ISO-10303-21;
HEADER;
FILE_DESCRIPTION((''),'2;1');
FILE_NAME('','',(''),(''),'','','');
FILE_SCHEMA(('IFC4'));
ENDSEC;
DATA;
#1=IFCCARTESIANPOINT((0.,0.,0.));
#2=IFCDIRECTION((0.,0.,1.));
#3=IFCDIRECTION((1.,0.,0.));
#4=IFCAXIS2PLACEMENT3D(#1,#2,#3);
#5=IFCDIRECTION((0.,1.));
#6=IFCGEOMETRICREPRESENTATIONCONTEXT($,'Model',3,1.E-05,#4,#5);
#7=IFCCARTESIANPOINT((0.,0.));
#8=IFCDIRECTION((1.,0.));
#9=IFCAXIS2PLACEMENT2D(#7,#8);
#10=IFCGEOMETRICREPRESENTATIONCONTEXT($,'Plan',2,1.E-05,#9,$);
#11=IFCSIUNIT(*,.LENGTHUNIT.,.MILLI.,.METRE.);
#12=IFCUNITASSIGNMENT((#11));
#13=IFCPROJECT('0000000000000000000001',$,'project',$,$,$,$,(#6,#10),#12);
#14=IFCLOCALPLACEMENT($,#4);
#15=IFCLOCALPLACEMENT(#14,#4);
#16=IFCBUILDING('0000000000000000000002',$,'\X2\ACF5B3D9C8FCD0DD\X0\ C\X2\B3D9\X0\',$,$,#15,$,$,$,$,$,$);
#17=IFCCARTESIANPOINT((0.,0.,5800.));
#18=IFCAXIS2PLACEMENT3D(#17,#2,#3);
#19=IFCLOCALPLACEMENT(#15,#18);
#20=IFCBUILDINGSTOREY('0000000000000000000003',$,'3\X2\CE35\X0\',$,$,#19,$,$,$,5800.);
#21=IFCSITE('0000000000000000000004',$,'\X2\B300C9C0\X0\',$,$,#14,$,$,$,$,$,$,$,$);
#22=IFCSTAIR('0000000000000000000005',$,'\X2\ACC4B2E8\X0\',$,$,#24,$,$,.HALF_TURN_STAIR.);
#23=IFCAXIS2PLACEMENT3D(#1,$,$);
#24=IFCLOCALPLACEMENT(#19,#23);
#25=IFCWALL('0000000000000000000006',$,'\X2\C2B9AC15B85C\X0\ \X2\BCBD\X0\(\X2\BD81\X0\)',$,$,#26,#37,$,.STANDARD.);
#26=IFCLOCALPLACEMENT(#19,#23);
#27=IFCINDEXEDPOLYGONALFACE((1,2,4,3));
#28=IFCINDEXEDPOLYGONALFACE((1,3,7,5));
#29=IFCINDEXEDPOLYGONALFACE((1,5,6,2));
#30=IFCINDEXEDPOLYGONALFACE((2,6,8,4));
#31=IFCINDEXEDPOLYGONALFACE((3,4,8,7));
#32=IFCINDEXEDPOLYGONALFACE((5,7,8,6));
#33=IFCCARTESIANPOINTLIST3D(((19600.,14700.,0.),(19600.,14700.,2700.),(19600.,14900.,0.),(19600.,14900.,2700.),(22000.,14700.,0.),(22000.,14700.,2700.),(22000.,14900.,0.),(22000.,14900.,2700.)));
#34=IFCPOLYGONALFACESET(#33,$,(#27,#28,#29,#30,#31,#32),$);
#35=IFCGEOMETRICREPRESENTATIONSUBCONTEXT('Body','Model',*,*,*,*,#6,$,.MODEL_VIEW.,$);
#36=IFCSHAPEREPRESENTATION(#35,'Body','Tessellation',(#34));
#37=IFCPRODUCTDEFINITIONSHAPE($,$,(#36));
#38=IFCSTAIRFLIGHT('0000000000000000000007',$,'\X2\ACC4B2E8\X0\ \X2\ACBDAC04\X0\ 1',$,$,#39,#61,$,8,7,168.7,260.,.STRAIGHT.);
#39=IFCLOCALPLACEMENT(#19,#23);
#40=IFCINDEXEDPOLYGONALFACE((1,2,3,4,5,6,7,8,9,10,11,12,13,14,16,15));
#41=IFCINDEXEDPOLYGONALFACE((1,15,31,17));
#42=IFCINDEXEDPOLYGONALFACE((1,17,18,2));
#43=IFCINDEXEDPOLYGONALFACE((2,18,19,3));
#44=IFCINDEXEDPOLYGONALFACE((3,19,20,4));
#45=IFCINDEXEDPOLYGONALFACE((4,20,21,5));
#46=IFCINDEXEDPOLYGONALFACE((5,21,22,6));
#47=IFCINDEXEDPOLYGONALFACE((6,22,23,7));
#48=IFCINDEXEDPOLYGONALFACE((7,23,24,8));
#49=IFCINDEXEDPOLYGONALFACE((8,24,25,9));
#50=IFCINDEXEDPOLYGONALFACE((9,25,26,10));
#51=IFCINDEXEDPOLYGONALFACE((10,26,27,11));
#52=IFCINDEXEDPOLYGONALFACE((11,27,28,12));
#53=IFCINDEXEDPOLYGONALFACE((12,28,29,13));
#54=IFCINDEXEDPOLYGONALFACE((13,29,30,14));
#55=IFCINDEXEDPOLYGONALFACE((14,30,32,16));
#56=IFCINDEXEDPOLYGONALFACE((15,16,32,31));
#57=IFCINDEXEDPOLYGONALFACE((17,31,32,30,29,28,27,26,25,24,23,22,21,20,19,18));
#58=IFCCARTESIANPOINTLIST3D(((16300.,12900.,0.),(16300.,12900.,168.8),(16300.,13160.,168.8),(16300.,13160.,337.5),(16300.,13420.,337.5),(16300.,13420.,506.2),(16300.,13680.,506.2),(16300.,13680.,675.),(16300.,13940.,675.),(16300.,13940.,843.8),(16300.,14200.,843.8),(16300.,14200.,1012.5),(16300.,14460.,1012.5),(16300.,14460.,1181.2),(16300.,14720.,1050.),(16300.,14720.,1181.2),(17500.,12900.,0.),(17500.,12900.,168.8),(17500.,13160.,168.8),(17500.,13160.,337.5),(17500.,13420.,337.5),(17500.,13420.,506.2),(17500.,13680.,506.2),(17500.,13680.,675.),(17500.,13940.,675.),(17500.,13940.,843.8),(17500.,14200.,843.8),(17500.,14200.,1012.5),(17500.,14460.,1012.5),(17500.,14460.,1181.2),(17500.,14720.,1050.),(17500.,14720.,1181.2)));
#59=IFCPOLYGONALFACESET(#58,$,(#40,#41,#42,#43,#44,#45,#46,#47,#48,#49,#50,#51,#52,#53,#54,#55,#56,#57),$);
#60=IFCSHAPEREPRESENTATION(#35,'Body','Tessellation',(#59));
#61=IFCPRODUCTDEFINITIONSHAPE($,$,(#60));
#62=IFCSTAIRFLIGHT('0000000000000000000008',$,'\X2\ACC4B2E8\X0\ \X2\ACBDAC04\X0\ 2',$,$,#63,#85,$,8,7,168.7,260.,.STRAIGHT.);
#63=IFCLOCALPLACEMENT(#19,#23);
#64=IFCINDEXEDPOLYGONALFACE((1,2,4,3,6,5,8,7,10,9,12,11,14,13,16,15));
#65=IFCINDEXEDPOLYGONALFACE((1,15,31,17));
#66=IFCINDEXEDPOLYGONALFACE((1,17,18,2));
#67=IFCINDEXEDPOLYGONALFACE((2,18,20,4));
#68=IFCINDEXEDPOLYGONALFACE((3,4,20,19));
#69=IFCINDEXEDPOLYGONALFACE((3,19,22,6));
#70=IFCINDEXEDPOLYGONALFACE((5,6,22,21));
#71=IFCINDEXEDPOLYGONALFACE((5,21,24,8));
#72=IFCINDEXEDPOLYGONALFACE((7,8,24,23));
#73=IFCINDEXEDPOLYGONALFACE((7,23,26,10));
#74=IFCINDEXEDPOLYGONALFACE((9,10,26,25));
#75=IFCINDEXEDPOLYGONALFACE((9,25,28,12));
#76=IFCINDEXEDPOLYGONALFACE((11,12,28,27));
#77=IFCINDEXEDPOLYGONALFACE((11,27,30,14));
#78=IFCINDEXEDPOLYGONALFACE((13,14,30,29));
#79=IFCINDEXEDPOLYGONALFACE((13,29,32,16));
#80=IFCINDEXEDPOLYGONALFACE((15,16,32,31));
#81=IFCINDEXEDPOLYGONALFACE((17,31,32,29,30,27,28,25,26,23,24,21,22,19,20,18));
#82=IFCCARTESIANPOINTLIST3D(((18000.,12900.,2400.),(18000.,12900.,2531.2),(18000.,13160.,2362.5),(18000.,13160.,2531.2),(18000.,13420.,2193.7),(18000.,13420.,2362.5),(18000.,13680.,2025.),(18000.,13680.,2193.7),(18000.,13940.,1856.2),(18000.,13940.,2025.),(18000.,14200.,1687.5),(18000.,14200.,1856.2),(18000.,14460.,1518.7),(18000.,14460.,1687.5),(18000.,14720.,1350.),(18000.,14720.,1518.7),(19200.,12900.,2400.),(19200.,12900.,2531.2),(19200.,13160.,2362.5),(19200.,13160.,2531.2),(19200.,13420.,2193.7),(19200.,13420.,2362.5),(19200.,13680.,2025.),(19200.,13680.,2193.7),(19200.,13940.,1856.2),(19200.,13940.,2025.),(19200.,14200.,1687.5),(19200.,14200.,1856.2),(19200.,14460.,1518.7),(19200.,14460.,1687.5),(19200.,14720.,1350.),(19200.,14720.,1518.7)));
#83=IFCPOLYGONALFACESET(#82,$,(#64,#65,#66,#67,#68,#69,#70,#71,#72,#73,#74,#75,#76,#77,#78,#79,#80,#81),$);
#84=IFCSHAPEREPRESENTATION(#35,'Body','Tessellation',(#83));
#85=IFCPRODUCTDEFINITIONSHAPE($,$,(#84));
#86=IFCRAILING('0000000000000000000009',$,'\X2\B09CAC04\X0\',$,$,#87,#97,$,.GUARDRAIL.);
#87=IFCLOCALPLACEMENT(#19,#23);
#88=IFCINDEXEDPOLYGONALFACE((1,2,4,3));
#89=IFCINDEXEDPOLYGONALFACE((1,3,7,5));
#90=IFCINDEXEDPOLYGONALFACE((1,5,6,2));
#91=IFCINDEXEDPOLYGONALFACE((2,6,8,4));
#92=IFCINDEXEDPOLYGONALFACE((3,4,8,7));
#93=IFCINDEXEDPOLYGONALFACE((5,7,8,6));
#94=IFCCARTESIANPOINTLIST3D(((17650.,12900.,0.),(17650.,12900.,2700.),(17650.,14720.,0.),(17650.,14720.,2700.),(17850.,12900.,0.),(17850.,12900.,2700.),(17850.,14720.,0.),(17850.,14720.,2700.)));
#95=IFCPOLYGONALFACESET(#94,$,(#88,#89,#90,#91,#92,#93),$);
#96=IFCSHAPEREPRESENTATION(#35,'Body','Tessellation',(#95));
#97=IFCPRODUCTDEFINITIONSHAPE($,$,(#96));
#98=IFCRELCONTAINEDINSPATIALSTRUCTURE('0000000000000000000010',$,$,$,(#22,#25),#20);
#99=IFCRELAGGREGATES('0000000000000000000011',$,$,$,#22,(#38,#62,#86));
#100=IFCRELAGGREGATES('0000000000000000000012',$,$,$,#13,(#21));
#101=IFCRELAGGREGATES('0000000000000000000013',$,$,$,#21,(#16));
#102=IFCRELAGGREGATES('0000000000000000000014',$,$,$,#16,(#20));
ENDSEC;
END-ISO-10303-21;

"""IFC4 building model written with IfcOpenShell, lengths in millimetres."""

from ifc_helpers import new_model, si_unit, direction, frame, origin_with_axes, origin_2d_with_axis, place, context, subcontext, project, spatial, polyline, outline, extrude, element, aggregate, save


model = new_model("IFC4")

# Units and contexts
model_context = context("Model", 3, precision=1e-05, world=origin_with_axes(), true_north=direction((0.0, 1.0)))
plan_context = context("Plan", 2, precision=1e-05, world=origin_2d_with_axis())
body_context = subcontext(model_context, "Body", "Model", "MODEL_VIEW")
ifc_project = project(units=[si_unit("LENGTHUNIT", "METRE", prefix="MILLI")], contexts=[model_context, plan_context])

# Site, building, storey
site_placement = place(None, origin_with_axes())
site = spatial("IfcSite", under=ifc_project, at=site_placement, Name="대지")
building_placement = place(site_placement, origin_with_axes())
building = spatial("IfcBuilding", under=site, at=building_placement, Name="공동주택 C동")
storey_placement = place(building_placement, frame((0.0, 0.0, 5800.0), z_axis=(0.0, 0.0, 1.0), x_axis=(1.0, 0.0, 0.0)))
storey = spatial("IfcBuildingStorey", under=building, at=storey_placement, Name="3층", Elevation=5800.0)

# Stair
stair_placement = place(storey_placement, origin_with_axes())
stair = element("IfcStair", 1, at=stair_placement, inside=storey, Name="계단", PredefinedType="HALF_TURN_STAIR")

# Wall
wall_1_placement = place(storey_placement, origin_with_axes())
element("IfcWall", 2, at=wall_1_placement, inside=storey, Name="승강로 벽(북)", PredefinedType="STANDARD", context=body_context, shape_type="SweptSolid", body=[
    extrude(outline(polyline([(19600.0, 14900.0), (22000.0, 14900.0), (22000.0, 14700.0), (19600.0, 14700.0), (19600.0, 14900.0)])), origin_with_axes(), (0.0, 0.0, 1.0), 2700.0),
])

# Stair flights
stair_flight_1_placement = place(stair_placement, origin_with_axes())
stair_flight_1 = element("IfcStairFlight", 3, at=stair_flight_1_placement, Name="계단 경간 1", NumberOfRisers=8, NumberOfTreads=7, PredefinedType="STRAIGHT", RiserHeight=168.7, TreadLength=260.0, context=body_context, shape_type="SweptSolid", body=[
    extrude(outline(polyline([(0.0, 0.0), (0.0, 168.7), (260.0, 168.7), (260.0, 337.5), (520.0, 337.5), (520.0, 506.2), (780.0, 506.2), (780.0, 675.0), (1040.0, 675.0), (1040.0, 843.7), (1300.0, 843.7), (1300.0, 1012.5), (1560.0, 1012.5), (1560.0, 1181.2), (1820.0, 1181.2), (1820.0, 1350.0), (1820.0, 1050.0), (0.0, 0.0)])), frame((16300.0, 12900.0, 0.0), z_axis=(1.0, 0.0, 0.0), x_axis=(0.0, 1.0, 0.0)), (0.0, 0.0, 1.0), 1200.0),
])
stair_flight_2_placement = place(stair_placement, origin_with_axes())
stair_flight_2 = element("IfcStairFlight", 4, at=stair_flight_2_placement, Name="계단 경간 2", NumberOfRisers=8, NumberOfTreads=7, PredefinedType="STRAIGHT", RiserHeight=168.7, TreadLength=260.0, context=body_context, shape_type="SweptSolid", body=[
    extrude(outline(polyline([(0.0, 0.0), (0.0, 168.7), (260.0, 168.7), (260.0, 337.5), (520.0, 337.5), (520.0, 506.2), (780.0, 506.2), (780.0, 675.0), (1040.0, 675.0), (1040.0, 843.7), (1300.0, 843.7), (1300.0, 1012.5), (1560.0, 1012.5), (1560.0, 1181.2), (1820.0, 1181.2), (1820.0, 1350.0), (1820.0, 1050.0), (0.0, 0.0)])), frame((19200.0, 14720.0, 1350.0), z_axis=(-1.0, 0.0, 0.0), x_axis=(0.0, -1.0, 0.0)), (0.0, 0.0, 1.0), 1200.0),
])

# Railing
railing_placement = place(stair_placement, origin_with_axes())
railing = element("IfcRailing", 5, at=railing_placement, Name="난간", PredefinedType="GUARDRAIL", context=body_context, shape_type="SweptSolid", body=[
    extrude(outline(polyline([(17650.0, 12900.0), (17850.0, 12900.0), (17850.0, 14720.0), (17650.0, 14720.0), (17650.0, 12900.0)])), origin_with_axes(), (0.0, 0.0, 1.0), 2700.0),
])
aggregate(stair, [stair_flight_1, stair_flight_2, railing])

save(model, "model.ifc")
